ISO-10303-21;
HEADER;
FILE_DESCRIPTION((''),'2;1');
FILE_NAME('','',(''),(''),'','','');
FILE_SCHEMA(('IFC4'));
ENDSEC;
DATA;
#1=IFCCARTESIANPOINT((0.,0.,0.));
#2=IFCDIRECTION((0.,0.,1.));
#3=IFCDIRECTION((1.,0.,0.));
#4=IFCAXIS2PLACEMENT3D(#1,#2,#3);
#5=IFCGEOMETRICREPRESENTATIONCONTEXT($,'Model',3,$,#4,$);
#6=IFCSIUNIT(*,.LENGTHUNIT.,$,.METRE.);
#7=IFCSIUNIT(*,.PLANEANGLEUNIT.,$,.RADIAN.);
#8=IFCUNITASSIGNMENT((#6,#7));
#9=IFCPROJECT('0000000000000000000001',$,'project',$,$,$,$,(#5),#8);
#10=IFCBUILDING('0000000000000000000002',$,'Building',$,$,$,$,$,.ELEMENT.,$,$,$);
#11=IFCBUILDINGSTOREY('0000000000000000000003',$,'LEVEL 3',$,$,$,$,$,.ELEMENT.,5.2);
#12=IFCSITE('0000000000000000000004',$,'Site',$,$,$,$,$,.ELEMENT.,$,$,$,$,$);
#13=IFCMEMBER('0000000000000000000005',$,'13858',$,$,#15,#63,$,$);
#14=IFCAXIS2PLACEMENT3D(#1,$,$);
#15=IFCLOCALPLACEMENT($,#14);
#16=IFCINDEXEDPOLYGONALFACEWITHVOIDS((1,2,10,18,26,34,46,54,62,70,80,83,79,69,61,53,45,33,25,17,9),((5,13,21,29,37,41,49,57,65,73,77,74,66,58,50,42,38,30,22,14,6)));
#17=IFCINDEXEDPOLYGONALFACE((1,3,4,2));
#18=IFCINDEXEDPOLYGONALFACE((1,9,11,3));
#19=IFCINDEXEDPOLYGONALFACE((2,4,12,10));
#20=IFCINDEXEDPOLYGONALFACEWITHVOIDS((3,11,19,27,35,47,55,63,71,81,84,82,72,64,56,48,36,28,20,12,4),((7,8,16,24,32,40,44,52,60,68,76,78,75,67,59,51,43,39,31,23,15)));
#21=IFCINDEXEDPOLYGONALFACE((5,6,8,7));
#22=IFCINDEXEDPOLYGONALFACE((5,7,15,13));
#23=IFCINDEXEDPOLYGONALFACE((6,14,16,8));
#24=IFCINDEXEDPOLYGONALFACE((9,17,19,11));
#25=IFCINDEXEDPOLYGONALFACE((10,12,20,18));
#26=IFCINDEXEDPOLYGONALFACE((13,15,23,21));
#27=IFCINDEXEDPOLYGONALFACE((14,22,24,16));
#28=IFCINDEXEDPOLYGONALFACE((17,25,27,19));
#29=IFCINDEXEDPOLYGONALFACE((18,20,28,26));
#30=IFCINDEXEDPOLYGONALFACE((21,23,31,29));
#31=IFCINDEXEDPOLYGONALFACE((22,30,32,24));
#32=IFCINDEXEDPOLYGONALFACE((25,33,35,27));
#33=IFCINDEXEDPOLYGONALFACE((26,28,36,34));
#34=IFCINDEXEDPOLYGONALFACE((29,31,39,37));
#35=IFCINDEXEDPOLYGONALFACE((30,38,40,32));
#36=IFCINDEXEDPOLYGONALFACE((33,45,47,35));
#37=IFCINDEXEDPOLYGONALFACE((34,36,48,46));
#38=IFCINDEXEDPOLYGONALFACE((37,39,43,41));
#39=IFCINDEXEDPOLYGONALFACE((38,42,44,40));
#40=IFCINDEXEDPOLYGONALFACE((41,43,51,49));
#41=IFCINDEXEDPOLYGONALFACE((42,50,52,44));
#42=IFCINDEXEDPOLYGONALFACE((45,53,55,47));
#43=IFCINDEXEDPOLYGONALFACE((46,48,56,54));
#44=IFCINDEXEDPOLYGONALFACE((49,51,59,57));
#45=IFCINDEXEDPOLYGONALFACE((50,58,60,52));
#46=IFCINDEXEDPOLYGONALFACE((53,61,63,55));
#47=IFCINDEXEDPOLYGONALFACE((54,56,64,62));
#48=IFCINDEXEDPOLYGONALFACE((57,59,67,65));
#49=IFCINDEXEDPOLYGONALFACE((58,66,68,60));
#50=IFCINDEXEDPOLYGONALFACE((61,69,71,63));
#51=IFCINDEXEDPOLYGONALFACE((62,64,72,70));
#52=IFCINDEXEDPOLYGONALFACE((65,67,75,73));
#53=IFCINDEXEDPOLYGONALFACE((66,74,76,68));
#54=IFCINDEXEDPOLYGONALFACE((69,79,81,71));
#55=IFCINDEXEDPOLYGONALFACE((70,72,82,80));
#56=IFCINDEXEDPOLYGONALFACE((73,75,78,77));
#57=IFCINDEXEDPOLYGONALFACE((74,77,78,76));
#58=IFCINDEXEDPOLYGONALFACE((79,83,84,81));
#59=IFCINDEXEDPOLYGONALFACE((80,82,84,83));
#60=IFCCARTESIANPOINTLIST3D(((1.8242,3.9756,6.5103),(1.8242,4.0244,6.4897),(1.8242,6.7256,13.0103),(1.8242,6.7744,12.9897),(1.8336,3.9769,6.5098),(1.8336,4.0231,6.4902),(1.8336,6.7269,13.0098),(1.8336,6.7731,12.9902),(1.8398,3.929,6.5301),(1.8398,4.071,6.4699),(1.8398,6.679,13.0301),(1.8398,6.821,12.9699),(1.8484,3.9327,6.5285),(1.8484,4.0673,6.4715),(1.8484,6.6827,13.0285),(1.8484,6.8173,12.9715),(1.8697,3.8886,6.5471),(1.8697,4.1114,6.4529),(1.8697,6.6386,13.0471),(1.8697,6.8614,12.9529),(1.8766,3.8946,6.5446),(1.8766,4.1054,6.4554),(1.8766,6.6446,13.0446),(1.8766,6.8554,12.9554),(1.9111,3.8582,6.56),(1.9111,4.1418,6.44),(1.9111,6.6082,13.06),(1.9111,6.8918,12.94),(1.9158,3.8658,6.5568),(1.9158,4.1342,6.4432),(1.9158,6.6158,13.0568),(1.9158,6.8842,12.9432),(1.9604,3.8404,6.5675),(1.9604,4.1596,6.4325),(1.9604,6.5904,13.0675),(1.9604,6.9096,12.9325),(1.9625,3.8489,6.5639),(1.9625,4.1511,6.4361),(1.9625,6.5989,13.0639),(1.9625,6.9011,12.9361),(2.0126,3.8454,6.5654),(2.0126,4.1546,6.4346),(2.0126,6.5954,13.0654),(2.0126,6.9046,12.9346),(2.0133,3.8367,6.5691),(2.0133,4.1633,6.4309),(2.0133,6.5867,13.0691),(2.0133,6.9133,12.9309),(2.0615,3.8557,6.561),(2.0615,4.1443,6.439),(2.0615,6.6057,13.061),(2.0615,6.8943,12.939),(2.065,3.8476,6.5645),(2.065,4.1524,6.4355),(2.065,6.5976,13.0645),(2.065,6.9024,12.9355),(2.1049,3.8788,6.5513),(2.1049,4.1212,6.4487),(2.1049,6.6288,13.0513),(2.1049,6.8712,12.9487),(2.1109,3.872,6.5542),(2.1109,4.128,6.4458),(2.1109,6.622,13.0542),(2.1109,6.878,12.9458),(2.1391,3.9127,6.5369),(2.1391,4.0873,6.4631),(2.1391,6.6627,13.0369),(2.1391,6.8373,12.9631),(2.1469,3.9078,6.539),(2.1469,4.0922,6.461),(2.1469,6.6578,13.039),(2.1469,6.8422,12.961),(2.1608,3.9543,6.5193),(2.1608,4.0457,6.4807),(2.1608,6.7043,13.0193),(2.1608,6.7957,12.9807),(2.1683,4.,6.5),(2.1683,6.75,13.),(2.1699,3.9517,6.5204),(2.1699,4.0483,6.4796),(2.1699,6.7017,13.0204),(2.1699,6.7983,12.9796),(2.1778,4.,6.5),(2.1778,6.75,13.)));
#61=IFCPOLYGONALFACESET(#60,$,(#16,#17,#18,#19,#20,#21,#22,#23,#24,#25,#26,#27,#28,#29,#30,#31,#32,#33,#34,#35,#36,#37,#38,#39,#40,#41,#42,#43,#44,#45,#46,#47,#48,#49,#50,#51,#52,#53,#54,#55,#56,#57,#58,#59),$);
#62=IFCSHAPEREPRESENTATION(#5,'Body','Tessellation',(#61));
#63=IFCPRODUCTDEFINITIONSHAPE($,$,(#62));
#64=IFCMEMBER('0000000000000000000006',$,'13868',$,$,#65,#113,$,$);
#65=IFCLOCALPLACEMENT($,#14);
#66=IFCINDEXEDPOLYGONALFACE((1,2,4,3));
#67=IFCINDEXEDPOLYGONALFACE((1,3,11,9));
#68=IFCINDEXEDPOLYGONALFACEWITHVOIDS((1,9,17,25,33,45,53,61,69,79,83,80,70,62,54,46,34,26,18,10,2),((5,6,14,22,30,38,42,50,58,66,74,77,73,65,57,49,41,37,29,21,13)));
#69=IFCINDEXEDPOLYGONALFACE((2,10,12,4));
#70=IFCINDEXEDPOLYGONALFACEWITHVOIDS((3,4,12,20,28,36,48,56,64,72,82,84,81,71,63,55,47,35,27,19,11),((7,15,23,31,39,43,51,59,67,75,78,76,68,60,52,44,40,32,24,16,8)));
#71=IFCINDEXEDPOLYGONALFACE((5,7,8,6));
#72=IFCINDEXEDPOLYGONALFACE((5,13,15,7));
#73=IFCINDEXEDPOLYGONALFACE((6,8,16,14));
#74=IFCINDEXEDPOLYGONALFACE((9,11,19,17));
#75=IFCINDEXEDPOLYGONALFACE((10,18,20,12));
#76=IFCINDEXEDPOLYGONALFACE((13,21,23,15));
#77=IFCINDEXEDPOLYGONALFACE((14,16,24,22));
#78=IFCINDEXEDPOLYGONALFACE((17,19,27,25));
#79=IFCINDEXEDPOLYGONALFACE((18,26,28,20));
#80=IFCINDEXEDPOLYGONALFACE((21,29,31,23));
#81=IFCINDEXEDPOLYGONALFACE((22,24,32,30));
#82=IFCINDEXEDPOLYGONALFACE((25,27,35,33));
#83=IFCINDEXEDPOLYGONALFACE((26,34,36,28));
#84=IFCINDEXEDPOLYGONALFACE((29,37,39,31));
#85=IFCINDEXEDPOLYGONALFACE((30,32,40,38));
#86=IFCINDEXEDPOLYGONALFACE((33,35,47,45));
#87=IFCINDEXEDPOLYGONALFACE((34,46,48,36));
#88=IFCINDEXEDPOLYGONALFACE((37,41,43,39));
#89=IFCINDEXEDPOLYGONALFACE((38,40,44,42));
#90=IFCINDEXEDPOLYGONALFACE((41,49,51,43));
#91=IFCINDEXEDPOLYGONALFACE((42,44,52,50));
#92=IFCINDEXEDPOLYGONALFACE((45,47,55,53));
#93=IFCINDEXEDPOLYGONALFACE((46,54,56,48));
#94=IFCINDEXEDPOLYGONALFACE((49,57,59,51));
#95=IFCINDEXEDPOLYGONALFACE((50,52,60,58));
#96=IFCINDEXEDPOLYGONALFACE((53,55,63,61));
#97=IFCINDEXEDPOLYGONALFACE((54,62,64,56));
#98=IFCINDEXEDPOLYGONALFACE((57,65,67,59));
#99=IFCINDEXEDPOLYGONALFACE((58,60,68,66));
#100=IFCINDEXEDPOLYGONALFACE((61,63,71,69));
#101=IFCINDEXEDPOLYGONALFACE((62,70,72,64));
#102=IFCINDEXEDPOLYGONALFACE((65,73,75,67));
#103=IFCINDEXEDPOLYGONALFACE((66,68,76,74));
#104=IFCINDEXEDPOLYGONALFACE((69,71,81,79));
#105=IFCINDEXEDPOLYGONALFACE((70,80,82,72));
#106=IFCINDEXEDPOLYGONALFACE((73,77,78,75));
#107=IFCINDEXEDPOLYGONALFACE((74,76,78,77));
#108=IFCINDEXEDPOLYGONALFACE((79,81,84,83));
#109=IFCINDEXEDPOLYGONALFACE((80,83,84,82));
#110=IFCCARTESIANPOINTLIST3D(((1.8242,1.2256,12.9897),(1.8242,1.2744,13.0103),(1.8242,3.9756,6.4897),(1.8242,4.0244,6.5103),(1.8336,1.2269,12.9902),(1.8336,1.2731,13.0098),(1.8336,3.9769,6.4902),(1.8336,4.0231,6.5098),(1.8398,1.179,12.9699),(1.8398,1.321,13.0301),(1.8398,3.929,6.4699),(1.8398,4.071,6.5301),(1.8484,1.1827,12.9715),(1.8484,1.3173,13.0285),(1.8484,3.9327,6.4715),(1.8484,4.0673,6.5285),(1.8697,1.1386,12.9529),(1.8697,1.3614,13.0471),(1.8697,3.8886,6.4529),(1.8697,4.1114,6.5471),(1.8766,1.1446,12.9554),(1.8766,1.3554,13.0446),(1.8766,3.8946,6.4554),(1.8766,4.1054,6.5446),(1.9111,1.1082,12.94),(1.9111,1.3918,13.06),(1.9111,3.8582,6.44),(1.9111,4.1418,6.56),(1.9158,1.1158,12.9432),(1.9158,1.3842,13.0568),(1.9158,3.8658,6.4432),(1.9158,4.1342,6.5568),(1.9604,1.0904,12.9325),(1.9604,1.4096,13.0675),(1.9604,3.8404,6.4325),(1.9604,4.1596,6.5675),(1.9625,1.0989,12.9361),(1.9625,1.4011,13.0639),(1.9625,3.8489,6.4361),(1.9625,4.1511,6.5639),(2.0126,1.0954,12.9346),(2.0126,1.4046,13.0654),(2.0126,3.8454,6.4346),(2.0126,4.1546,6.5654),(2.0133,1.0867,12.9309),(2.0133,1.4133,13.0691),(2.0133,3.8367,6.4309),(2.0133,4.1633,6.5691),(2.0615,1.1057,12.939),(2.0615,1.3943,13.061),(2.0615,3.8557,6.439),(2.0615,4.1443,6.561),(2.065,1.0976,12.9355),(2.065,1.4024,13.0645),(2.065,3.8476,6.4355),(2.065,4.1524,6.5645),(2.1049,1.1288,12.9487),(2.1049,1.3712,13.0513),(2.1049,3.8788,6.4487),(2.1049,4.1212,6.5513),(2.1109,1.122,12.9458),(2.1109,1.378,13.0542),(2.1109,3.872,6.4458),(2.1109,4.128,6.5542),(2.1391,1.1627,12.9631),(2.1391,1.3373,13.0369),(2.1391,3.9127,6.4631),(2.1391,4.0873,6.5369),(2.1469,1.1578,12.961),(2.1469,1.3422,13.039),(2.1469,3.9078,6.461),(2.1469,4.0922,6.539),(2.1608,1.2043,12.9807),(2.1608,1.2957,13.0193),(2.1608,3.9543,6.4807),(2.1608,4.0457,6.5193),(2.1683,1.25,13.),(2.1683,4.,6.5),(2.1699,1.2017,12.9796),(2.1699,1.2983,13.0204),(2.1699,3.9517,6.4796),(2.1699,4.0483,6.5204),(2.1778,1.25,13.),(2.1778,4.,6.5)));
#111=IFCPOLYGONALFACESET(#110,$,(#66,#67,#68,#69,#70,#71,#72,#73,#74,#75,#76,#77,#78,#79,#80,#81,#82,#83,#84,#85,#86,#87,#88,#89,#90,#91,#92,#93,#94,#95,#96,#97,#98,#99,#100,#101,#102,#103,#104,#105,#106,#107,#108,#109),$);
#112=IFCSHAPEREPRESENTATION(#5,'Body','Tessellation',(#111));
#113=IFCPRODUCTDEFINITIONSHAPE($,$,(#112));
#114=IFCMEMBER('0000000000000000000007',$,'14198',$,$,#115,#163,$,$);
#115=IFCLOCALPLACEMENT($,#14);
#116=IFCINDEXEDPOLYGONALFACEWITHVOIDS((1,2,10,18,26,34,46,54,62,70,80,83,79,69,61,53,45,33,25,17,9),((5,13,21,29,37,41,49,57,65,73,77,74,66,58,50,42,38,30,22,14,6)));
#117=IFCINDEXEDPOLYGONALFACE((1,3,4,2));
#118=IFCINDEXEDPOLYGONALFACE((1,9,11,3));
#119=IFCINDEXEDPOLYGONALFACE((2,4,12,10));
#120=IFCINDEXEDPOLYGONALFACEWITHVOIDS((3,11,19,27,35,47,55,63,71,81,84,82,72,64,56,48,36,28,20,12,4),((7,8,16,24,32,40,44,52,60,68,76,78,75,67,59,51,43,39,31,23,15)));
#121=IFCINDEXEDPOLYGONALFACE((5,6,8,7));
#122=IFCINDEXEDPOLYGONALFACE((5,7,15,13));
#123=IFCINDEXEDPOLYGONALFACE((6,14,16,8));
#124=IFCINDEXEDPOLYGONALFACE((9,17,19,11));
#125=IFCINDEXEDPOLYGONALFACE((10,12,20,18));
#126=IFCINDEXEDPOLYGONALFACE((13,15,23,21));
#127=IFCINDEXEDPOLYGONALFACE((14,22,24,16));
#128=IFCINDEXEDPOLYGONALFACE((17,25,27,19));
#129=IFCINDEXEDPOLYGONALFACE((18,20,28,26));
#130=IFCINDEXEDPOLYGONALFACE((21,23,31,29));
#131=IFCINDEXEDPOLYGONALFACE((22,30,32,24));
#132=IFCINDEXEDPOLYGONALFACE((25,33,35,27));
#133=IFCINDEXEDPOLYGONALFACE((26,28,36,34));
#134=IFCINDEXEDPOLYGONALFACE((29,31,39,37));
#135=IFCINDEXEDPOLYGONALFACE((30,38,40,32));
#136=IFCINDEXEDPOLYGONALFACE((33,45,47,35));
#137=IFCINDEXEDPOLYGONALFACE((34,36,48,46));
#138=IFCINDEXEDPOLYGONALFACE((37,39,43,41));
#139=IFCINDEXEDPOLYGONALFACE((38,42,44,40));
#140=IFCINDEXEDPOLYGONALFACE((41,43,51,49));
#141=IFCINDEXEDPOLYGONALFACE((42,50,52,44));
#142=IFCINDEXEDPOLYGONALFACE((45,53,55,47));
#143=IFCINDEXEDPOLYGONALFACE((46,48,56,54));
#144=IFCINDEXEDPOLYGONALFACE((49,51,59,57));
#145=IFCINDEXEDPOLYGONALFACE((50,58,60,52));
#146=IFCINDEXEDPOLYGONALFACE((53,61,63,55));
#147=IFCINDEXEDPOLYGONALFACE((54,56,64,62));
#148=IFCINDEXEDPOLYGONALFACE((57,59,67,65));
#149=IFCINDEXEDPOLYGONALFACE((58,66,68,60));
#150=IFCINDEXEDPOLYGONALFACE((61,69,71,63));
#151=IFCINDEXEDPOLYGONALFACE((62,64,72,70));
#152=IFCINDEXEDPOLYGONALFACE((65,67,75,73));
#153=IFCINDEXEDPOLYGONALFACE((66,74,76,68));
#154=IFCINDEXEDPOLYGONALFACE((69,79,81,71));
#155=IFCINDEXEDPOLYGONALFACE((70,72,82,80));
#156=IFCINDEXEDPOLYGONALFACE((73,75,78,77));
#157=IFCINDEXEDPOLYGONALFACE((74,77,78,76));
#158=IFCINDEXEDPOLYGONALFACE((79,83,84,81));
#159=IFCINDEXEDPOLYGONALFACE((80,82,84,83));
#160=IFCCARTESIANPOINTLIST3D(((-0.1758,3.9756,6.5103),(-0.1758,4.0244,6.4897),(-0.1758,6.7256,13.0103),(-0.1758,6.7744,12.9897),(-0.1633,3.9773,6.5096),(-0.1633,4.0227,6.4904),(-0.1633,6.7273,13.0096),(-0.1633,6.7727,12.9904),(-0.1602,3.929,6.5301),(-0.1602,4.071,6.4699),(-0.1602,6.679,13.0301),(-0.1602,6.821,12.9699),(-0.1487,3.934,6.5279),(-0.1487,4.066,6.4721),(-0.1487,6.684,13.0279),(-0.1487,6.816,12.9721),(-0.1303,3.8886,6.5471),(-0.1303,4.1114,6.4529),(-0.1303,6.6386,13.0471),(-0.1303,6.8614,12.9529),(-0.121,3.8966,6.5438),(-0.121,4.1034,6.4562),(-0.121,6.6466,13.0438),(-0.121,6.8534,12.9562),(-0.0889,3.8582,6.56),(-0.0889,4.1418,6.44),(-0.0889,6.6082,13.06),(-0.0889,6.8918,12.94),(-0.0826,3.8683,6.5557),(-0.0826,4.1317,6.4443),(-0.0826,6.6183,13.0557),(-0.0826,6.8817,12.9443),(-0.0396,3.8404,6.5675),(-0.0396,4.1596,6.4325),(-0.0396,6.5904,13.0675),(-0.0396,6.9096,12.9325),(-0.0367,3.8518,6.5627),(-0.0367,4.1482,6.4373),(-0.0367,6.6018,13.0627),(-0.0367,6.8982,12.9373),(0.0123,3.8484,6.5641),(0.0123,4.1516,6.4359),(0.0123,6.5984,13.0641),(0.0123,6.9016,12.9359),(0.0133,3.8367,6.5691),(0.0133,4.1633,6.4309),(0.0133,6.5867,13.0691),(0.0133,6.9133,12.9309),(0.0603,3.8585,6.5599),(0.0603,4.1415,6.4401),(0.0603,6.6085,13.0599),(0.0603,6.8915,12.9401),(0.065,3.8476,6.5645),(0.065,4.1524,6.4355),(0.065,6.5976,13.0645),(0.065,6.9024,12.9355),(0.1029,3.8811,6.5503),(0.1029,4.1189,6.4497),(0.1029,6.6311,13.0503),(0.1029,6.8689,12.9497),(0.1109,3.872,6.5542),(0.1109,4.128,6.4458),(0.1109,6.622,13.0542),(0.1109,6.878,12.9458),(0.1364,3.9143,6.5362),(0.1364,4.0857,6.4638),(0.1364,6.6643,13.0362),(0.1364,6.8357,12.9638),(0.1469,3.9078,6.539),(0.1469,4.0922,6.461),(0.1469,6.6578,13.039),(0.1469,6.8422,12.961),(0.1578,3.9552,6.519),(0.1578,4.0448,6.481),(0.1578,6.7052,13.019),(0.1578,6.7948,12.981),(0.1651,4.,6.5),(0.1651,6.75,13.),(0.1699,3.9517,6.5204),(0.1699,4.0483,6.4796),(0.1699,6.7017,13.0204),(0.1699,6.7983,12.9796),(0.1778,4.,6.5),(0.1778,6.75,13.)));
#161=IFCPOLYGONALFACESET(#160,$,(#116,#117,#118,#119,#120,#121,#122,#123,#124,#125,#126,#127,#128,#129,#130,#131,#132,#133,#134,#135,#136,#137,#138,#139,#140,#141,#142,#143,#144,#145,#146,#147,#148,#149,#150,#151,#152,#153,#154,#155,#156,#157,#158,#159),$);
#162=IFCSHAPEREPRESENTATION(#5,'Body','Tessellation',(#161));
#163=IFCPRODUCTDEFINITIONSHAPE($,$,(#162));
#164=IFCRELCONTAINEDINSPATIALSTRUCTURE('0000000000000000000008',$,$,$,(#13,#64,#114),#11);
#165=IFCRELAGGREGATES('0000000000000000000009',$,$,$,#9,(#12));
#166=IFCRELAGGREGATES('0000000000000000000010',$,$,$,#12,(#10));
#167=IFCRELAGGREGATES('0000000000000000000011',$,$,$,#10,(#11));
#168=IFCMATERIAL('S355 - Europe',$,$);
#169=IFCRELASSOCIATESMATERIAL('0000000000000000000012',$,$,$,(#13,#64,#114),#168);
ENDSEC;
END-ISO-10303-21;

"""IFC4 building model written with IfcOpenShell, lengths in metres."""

from ifc_helpers import new_model, si_unit, frame, origin_with_axes, origin_2d_with_axis, place, context, project, spatial, hollow_circle, extrude, material, material_profile, profile_set, profile_usage, element, save


model = new_model("IFC4")

# Units and contexts
model_context = context("Model", 3, world=origin_with_axes())
ifc_project = project(units=[si_unit("LENGTHUNIT", "METRE"), si_unit("PLANEANGLEUNIT", "RADIAN")], contexts=[model_context])

# Site, building, storey
site = spatial("IfcSite", under=ifc_project, Name="Site", CompositionType="ELEMENT")
building = spatial("IfcBuilding", under=site, Name="Building", CompositionType="ELEMENT")
storey = spatial("IfcBuildingStorey", under=building, Name="LEVEL 3", CompositionType="ELEMENT", Elevation=5.2)

# Shared definitions
ifc_material = material(Name="S355 - Europe")

# Members
ifc_material_profile_1 = material_profile(ifc_material, hollow_circle(Radius=0.1778, WallThickness=0.0095, at=origin_2d_with_axis()))
ifc_profile_set_1 = profile_set([ifc_material_profile_1])
ifc_profile_usage_1 = profile_usage(ifc_profile_set_1, cardinal=10)
member_1_placement = place(None, frame((2.0, 6.75, 13.0), z_axis=(0.0, -0.38964, -0.920967), x_axis=(1.0, 0.0, 0.0)))
element("IfcMember", 1, at=member_1_placement, inside=storey, material=ifc_profile_usage_1, Name="13858", context=model_context, shape_type="SweptSolid", body=[
    extrude(hollow_circle(Radius=0.1778, WallThickness=0.0095, at=origin_2d_with_axis()), origin_with_axes(), (0.0, 0.0, 1.0), 7.0578),
])
ifc_material_profile_2 = material_profile(ifc_material, hollow_circle(Radius=0.1778, WallThickness=0.0095, at=origin_2d_with_axis()))
ifc_profile_set_2 = profile_set([ifc_material_profile_2])
ifc_profile_usage_2 = profile_usage(ifc_profile_set_2, cardinal=10)
member_2_placement = place(None, frame((2.0, 4.0, 6.5), z_axis=(0.0, -0.38964, 0.920967), x_axis=(1.0, 0.0, 0.0)))
element("IfcMember", 2, at=member_2_placement, inside=storey, material=ifc_profile_usage_2, Name="13868", context=model_context, shape_type="SweptSolid", body=[
    extrude(hollow_circle(Radius=0.1778, WallThickness=0.0095, at=origin_2d_with_axis()), origin_with_axes(), (0.0, 0.0, 1.0), 7.0578),
])
ifc_material_profile_3 = material_profile(ifc_material, hollow_circle(Radius=0.1778, WallThickness=0.0127, at=origin_2d_with_axis()))
ifc_profile_set_3 = profile_set([ifc_material_profile_3])
ifc_profile_usage_3 = profile_usage(ifc_profile_set_3, cardinal=10)
member_3_placement = place(None, frame((0.0, 6.75, 13.0), z_axis=(0.0, -0.38964, -0.920967), x_axis=(1.0, 0.0, 0.0)))
element("IfcMember", 3, at=member_3_placement, inside=storey, material=ifc_profile_usage_3, Name="14198", context=model_context, shape_type="SweptSolid", body=[
    extrude(hollow_circle(Radius=0.1778, WallThickness=0.0127, at=origin_2d_with_axis()), origin_with_axes(), (0.0, 0.0, 1.0), 7.0578),
])

save(model, "model.ifc")
